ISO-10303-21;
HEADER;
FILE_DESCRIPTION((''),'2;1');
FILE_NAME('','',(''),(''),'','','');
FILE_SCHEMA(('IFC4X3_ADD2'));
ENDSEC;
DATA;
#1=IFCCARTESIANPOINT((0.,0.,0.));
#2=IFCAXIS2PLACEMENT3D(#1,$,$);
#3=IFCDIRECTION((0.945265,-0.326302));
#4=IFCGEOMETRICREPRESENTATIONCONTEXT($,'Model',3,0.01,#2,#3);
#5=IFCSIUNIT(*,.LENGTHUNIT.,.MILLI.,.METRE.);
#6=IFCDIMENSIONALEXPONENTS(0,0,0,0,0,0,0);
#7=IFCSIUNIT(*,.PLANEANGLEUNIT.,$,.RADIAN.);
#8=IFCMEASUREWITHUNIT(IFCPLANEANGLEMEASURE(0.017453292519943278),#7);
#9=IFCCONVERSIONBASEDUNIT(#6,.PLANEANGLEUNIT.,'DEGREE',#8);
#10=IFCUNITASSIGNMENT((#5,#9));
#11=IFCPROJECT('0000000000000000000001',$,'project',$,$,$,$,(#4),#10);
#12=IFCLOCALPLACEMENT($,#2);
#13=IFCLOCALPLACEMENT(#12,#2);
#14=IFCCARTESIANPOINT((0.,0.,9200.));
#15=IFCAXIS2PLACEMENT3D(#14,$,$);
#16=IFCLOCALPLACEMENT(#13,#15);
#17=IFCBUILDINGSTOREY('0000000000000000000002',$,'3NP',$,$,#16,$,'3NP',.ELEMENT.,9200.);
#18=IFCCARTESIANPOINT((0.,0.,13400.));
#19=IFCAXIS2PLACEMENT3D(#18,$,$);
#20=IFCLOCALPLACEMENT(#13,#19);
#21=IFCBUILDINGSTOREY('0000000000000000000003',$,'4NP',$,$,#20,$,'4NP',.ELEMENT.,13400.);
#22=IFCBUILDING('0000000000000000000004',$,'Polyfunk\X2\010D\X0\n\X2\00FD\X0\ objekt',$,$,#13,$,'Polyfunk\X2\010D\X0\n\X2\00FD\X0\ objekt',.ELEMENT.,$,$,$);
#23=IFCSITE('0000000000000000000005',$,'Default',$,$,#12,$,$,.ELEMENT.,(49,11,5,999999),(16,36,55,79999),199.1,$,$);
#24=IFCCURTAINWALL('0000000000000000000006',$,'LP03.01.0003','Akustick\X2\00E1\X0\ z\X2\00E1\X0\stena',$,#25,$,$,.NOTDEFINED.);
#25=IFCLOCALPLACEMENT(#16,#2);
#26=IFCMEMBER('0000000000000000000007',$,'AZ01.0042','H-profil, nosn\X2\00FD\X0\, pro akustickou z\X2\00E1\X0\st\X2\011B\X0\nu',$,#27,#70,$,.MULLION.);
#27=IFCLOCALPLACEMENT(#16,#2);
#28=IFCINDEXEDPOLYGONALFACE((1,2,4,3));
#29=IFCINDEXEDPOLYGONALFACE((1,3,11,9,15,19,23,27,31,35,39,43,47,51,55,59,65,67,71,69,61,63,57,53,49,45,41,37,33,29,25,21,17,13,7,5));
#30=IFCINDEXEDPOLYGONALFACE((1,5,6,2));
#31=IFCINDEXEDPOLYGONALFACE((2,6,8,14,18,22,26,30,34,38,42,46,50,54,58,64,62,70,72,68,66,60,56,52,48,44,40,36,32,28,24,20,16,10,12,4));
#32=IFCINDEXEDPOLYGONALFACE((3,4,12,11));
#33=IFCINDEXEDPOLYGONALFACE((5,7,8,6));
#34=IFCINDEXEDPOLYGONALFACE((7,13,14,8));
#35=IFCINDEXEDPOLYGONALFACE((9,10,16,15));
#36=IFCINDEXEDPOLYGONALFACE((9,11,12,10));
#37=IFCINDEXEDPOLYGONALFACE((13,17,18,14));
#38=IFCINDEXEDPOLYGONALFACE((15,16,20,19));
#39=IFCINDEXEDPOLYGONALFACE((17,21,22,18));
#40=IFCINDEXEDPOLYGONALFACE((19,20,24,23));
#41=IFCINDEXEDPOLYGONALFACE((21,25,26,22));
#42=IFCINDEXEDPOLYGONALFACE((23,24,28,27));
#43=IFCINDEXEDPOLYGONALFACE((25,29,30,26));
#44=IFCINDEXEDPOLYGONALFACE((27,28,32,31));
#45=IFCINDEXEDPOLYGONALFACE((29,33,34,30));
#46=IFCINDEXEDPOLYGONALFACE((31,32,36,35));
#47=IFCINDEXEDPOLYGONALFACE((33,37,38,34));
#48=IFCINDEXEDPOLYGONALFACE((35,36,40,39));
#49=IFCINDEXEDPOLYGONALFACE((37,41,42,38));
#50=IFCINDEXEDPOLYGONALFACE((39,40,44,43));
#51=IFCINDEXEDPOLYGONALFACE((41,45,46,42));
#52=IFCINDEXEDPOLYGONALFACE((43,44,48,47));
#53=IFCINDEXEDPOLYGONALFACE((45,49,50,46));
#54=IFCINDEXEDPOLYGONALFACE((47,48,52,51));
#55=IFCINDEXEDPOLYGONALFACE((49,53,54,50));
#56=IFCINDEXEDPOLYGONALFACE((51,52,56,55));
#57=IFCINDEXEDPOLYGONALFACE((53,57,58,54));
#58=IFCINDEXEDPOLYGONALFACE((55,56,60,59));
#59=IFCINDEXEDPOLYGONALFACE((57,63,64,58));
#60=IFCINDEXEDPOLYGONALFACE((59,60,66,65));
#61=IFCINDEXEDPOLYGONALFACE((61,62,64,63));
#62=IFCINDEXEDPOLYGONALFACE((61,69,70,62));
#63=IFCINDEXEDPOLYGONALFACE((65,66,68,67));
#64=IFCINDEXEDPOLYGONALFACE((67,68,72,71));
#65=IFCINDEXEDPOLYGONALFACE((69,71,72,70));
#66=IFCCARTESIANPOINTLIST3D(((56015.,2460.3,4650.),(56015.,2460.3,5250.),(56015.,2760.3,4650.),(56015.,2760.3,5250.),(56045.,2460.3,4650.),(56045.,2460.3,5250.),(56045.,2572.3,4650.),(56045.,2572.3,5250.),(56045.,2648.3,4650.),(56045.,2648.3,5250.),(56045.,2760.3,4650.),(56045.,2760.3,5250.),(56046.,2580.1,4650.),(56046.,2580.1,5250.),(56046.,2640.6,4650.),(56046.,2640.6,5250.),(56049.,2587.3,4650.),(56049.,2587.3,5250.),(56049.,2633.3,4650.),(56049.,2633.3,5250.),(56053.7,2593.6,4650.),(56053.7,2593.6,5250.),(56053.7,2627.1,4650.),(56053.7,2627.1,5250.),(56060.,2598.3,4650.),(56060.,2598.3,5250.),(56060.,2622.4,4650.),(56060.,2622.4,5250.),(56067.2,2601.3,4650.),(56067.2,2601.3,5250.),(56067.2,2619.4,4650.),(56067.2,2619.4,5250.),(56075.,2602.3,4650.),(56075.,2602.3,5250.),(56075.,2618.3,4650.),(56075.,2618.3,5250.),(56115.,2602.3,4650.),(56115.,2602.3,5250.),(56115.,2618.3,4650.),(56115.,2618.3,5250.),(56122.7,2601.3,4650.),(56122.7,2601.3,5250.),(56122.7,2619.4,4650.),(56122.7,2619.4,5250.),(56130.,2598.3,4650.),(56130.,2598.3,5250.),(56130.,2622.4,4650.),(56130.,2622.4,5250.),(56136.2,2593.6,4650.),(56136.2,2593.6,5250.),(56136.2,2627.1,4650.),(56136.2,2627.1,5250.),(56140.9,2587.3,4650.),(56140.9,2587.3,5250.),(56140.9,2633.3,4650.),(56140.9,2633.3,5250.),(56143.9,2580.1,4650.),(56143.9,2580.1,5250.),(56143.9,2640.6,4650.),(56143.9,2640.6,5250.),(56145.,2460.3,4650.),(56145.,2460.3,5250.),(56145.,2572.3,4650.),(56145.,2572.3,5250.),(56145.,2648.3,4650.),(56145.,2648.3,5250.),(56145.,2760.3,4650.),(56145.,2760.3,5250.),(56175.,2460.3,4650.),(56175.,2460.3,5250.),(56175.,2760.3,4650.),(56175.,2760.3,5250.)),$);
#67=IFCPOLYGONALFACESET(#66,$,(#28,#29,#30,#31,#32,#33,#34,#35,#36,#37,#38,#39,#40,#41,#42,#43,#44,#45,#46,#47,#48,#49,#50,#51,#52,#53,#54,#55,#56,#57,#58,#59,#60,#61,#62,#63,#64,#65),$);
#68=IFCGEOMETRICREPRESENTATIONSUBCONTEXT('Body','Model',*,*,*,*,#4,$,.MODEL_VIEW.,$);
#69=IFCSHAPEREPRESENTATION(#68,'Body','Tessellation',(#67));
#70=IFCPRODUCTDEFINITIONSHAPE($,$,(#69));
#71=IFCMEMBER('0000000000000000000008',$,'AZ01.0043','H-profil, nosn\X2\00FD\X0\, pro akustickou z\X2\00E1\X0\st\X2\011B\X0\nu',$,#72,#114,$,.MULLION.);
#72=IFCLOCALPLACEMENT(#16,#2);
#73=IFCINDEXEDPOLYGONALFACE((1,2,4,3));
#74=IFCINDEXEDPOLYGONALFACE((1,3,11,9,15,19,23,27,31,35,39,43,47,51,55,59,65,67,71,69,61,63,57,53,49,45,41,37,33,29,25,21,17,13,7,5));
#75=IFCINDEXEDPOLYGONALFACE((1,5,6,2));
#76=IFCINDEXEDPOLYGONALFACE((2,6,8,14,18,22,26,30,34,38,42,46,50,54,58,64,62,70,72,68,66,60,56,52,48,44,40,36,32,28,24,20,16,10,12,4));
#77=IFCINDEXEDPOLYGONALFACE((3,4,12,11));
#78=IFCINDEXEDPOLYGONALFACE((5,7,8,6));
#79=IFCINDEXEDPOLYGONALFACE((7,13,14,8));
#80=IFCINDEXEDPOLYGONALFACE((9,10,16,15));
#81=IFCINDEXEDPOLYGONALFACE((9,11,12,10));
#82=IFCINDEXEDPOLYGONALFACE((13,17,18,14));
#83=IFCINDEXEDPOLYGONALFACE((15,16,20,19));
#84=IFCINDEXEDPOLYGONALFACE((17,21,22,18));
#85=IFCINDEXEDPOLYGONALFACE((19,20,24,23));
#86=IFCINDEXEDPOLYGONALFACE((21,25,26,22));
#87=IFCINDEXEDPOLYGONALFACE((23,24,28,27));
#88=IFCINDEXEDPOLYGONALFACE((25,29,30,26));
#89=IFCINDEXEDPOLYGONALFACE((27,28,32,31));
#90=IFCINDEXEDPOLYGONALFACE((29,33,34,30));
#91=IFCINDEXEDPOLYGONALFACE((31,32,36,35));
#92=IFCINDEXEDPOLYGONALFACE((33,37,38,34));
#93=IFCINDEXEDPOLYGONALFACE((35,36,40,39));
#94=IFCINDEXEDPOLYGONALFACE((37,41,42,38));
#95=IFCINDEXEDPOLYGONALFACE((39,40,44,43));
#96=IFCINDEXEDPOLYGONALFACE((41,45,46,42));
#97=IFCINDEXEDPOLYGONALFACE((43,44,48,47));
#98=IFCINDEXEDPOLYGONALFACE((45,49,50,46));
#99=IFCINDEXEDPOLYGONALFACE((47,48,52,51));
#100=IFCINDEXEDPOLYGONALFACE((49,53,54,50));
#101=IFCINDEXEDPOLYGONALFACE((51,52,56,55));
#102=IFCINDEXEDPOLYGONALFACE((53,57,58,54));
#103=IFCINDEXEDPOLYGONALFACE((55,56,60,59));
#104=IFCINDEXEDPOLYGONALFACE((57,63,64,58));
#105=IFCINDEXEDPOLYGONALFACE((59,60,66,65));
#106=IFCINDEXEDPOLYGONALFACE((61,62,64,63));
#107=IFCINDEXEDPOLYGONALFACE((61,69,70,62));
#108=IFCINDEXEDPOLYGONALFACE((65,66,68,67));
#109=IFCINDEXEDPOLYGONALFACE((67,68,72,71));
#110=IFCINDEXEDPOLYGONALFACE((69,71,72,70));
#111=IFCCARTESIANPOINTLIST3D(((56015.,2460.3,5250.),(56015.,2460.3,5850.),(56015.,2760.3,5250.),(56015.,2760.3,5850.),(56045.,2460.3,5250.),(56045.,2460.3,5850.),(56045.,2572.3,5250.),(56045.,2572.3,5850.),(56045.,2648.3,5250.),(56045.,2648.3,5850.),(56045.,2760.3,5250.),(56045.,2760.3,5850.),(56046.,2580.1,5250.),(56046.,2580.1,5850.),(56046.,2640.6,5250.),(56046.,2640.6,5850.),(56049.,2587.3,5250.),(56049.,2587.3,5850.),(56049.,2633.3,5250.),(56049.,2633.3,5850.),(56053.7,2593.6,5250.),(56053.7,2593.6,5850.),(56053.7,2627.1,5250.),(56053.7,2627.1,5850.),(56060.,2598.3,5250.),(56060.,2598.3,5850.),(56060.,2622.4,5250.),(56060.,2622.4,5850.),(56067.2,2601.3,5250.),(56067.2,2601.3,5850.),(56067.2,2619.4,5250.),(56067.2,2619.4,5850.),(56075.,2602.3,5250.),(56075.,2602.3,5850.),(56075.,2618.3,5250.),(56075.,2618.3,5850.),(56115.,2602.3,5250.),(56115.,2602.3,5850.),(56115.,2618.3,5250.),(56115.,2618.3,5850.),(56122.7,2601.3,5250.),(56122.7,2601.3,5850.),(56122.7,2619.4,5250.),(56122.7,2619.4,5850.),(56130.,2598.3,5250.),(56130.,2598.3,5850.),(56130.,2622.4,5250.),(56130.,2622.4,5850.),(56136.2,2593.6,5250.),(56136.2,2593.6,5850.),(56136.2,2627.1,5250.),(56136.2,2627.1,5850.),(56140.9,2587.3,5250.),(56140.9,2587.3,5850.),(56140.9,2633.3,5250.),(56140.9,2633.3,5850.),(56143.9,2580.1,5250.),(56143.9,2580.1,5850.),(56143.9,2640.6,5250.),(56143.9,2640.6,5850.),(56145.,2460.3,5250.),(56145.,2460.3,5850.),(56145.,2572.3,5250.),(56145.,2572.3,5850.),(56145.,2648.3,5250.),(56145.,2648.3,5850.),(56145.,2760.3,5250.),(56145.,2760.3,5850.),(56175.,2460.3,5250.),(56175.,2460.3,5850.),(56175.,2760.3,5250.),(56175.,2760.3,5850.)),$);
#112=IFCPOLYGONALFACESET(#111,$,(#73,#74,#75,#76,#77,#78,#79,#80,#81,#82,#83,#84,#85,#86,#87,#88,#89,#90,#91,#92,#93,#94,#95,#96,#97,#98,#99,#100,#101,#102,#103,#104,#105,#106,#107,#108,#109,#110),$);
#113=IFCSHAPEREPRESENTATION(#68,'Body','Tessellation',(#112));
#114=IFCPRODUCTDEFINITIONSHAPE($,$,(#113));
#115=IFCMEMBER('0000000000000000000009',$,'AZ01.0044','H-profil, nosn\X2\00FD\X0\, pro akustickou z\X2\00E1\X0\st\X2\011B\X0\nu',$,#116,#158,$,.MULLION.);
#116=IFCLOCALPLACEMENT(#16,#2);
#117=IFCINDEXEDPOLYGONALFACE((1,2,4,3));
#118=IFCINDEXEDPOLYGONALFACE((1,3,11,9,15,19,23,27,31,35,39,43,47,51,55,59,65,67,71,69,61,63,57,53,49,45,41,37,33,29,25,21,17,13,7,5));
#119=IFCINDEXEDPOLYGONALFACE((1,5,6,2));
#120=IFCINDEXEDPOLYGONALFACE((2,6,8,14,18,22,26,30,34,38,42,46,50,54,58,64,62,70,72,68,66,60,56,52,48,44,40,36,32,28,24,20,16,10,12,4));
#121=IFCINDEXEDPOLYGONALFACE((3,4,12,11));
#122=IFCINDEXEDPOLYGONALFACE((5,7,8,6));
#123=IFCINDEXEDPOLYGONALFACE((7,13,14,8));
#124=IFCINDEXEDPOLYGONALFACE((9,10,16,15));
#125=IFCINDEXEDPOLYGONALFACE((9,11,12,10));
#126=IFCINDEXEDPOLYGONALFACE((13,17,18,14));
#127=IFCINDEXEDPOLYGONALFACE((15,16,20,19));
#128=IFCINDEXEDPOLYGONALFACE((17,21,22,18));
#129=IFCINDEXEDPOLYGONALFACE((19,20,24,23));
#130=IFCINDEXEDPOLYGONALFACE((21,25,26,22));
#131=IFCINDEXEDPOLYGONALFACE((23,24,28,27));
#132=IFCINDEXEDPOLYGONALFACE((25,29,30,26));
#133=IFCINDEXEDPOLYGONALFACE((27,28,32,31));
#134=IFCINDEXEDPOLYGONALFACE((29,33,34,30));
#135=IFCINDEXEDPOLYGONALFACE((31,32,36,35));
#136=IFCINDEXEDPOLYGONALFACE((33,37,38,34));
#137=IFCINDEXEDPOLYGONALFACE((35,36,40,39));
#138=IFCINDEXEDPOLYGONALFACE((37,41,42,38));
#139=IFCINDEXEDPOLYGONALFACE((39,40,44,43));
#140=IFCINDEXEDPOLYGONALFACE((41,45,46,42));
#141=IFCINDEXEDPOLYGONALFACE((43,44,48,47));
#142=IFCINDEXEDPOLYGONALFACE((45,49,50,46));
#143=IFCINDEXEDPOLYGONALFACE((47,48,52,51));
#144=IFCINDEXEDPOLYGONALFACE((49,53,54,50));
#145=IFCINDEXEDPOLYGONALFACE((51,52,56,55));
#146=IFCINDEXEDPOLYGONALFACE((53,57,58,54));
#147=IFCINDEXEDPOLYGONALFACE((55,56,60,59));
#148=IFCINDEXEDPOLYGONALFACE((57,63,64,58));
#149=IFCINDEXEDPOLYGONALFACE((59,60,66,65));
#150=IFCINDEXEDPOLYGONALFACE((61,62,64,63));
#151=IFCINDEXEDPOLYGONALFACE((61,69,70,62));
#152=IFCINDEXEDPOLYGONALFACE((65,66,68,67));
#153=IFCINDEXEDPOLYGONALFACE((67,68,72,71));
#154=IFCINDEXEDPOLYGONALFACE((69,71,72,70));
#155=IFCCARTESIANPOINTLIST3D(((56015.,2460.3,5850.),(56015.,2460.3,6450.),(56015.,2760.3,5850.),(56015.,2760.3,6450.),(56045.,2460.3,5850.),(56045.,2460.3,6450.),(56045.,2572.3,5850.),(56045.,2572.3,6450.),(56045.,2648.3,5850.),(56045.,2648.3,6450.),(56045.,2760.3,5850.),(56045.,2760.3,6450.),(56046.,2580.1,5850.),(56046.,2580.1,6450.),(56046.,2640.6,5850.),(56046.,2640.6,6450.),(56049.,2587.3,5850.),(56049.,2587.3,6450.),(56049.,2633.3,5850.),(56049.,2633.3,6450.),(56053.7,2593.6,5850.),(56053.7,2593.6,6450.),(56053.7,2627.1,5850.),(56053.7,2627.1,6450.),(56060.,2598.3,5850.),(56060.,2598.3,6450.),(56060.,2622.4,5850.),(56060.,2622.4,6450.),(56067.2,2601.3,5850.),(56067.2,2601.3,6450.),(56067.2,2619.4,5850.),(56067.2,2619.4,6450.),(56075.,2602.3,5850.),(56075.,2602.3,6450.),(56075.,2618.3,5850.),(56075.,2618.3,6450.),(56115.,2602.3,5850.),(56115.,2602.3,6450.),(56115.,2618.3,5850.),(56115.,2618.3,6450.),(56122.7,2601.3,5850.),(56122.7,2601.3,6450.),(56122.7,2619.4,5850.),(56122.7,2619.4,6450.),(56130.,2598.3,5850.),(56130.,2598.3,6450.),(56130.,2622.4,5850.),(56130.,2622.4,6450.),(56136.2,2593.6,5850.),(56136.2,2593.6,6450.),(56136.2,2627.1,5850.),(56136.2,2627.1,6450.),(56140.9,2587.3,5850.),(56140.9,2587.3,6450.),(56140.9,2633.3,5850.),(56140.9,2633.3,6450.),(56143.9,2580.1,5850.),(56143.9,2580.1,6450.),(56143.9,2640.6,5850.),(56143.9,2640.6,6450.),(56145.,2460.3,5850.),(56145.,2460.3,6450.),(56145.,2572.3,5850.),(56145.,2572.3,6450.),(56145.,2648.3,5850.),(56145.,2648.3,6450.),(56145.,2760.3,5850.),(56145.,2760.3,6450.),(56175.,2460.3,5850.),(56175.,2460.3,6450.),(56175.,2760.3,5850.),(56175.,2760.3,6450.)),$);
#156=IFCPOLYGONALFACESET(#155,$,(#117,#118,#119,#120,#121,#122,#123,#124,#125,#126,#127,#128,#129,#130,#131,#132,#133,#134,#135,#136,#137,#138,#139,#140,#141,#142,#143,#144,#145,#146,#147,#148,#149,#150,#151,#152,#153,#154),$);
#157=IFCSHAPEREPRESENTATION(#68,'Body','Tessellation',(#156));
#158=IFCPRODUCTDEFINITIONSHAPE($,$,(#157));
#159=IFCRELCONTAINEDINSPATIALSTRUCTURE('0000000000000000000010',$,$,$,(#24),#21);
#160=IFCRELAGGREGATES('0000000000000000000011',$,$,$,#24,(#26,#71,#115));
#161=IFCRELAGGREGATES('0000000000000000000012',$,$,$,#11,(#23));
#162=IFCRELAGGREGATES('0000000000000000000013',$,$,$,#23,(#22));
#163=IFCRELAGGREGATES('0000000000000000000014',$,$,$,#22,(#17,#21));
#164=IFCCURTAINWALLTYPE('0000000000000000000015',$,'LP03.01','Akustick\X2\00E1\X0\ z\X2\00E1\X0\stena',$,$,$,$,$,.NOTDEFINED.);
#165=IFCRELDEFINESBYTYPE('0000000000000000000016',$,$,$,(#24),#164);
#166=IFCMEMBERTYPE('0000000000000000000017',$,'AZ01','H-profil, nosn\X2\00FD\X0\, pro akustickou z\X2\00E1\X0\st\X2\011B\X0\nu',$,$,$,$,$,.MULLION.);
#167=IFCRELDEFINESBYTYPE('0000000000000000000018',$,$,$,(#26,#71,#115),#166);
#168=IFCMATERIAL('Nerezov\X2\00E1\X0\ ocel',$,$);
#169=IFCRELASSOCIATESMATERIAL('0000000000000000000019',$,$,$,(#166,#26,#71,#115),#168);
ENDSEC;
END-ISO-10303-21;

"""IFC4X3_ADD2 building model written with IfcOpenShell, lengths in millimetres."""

from ifc_helpers import new_model, entity, si_unit, converted_unit, direction, frame, frame_2d, origin, place, context, subcontext, project, spatial, polyline, circle_curve, parameter, trimmed, segment, composite_curve, outline, extrude, source, transform, mapped, material, material_profile, profile_set, profile_usage, type_object, element, aggregate, save


model = new_model("IFC4X3_ADD2")

# Units and contexts
model_context = context("Model", 3, precision=0.01, world=origin(), true_north=direction((0.945265, -0.326302)))
body_context = subcontext(model_context, "Body", "Model", "MODEL_VIEW")
ifc_project = project(units=[si_unit("LENGTHUNIT", "METRE", prefix="MILLI"), converted_unit("PLANEANGLEUNIT", "DEGREE", entity("IfcPlaneAngleMeasure", 0.017453292519943278), si_unit("PLANEANGLEUNIT", "RADIAN"), dimensions=[0, 0, 0, 0, 0, 0, 0])], contexts=[model_context])

# Site, building, storey
site_placement = place(None, origin())
site = spatial("IfcSite", under=ifc_project, at=site_placement, Name="Default", CompositionType="ELEMENT", RefLatitude=(49, 11, 5, 999999), RefLongitude=(16, 36, 55, 79999), RefElevation=199.1)
building_placement = place(site_placement, origin())
building = spatial("IfcBuilding", under=site, at=building_placement, Name="Polyfunkčný objekt", LongName="Polyfunkčný objekt", CompositionType="ELEMENT")
storey_1_placement = place(building_placement, frame((0.0, 0.0, 9200.0)))
storey_1 = spatial("IfcBuildingStorey", under=building, at=storey_1_placement, Name="3NP", LongName="3NP", CompositionType="ELEMENT", Elevation=9200.0)

# Shared definitions
storey_2_placement = place(building_placement, frame((0.0, 0.0, 13400.0)))
storey_2 = spatial("IfcBuildingStorey", under=building, at=storey_2_placement, Name="4NP", LongName="4NP", CompositionType="ELEMENT", Elevation=13400.0)

# Shared definitions
curtain_wall_type_1 = type_object("IfcCurtainWallType", Name="LP03.01", Description="Akustická zástena", PredefinedType="NOTDEFINED")
ifc_material_1 = material(Name="Nerezová ocel")
ifc_material_profile_1 = material_profile(ifc_material_1, outline(composite_curve([segment(polyline([(50.0, -150.0), (80.0, -150.0)]), True, "CONTINUOUS"), segment(polyline([(80.0, -150.0), (80.0, 150.0)]), True, "CONTINUOUS"), segment(polyline([(80.0, 150.0), (50.0, 150.0)]), True, "CONTINUOUS"), segment(polyline([(50.0, 150.0), (50.0, 38.0)]), True, "CONTINUOUS"), segment(trimmed(circle_curve(frame_2d((20.0, 38.0), x_axis=(0.0, 1.0)), 30.0), [parameter(180.0)], [parameter(270.0)], True, "PARAMETER"), False, "CONTINUOUS"), segment(polyline([(20.0, 8.0), (-20.0, 8.0)]), True, "CONTINUOUS"), segment(trimmed(circle_curve(frame_2d((-20.0, 38.0), x_axis=(0.0, 1.0)), 30.0), [parameter(90.0)], [parameter(180.0)], True, "PARAMETER"), False, "CONTINUOUS"), segment(polyline([(-50.0, 38.0), (-50.0, 150.0)]), True, "CONTINUOUS"), segment(polyline([(-50.0, 150.0), (-80.0, 150.0)]), True, "CONTINUOUS"), segment(polyline([(-80.0, 150.0), (-80.0, -150.0)]), True, "CONTINUOUS"), segment(polyline([(-80.0, -150.0), (-50.0, -150.0)]), True, "CONTINUOUS"), segment(polyline([(-50.0, -150.0), (-50.0, -38.0)]), True, "CONTINUOUS"), segment(trimmed(circle_curve(frame_2d((-20.0, -38.0), x_axis=(0.0, 1.0)), 30.0), [parameter(0.0)], [parameter(90.0)], True, "PARAMETER"), False, "CONTINUOUS"), segment(polyline([(-20.0, -8.0), (20.0, -8.0)]), True, "CONTINUOUS"), segment(trimmed(circle_curve(frame_2d((20.0, -38.0), x_axis=(0.0, 1.0)), 30.0), [parameter(270.0)], [parameter(0.0)], True, "PARAMETER"), False, "CONTINUOUS"), segment(polyline([(50.0, -38.0), (50.0, -150.0)]), True, "CONTINUOUS")], self_intersect=False)), Name="Profil zástena")
ifc_profile_set_1 = profile_set([ifc_material_profile_1], Name="Profil zástena")
ifc_profile_usage_1 = profile_usage(ifc_profile_set_1)
member_type_1 = type_object("IfcMemberType", Name="AZ01", Description="H-profil, nosný, pro akustickou zástěnu", PredefinedType="MULLION", material=ifc_profile_set_1)

# Curtain wall, members
curtain_wall_1_placement = place(storey_2_placement, frame((0.0, 0.0, -13400.0)))
curtain_wall_1 = element("IfcCurtainWall", 1, at=curtain_wall_1_placement, inside=storey_2, type_object=curtain_wall_type_1, Name="LP03.01.0003", Description="Akustická zástena", PredefinedType="NOTDEFINED")
shared_shape_1 = source(origin(), body_context, "Body", "SweptSolid", [
    extrude(outline(composite_curve([segment(polyline([(-150.0, -50.0), (-150.0, -80.0)]), True, "CONTINUOUS"), segment(polyline([(-150.0, -80.0), (150.0, -80.0)]), True, "CONTINUOUS"), segment(polyline([(150.0, -80.0), (150.0, -50.0)]), True, "CONTINUOUS"), segment(polyline([(150.0, -50.0), (38.0, -50.0)]), True, "CONTINUOUS"), segment(trimmed(circle_curve(frame_2d((38.0, -20.0), x_axis=(1.0, 0.0)), 30.0), [parameter(180.0)], [parameter(270.0)], True, "PARAMETER"), False, "CONTINUOUS"), segment(polyline([(8.0, -20.0), (8.0, 20.0)]), True, "CONTINUOUS"), segment(trimmed(circle_curve(frame_2d((38.0, 20.0), x_axis=(1.0, 0.0)), 30.0), [parameter(90.0)], [parameter(180.0)], True, "PARAMETER"), False, "CONTINUOUS"), segment(polyline([(38.0, 50.0), (150.0, 50.0)]), True, "CONTINUOUS"), segment(polyline([(150.0, 50.0), (150.0, 80.0)]), True, "CONTINUOUS"), segment(polyline([(150.0, 80.0), (-150.0, 80.0)]), True, "CONTINUOUS"), segment(polyline([(-150.0, 80.0), (-150.0, 50.0)]), True, "CONTINUOUS"), segment(polyline([(-150.0, 50.0), (-38.0, 50.0)]), True, "CONTINUOUS"), segment(trimmed(circle_curve(frame_2d((-38.0, 20.0), x_axis=(1.0, 0.0)), 30.0), [parameter(0.0)], [parameter(90.0)], True, "PARAMETER"), False, "CONTINUOUS"), segment(polyline([(-8.0, 20.0), (-8.0, -20.0)]), True, "CONTINUOUS"), segment(trimmed(circle_curve(frame_2d((-38.0, -20.0), x_axis=(1.0, 0.0)), 30.0), [parameter(270.0)], [parameter(0.0)], True, "PARAMETER"), False, "CONTINUOUS"), segment(polyline([(-38.0, -50.0), (-150.0, -50.0)]), True, "CONTINUOUS")], self_intersect=False)), frame((0.0, 0.0, -600.0), z_axis=(0.0, 0.0, -1.0), x_axis=(1.0, 0.0, 0.0)), (0.0, 0.0, -1.0), 600.0),
])
member_1_placement = place(curtain_wall_1_placement, frame((56095.0, 2610.3, 13850.0), z_axis=(0.0, 0.0, -1.0), x_axis=(0.0, 1.0, 0.0)))
member_1 = element("IfcMember", 2, at=member_1_placement, type_object=member_type_1, material=ifc_profile_usage_1, Name="AZ01.0042", Description="H-profil, nosný, pro akustickou zástěnu", PredefinedType="MULLION", context=body_context, shape_type="MappedRepresentation", body=[
    mapped(shared_shape_1, transform((0.0, 0.0, 0.0), scale=1.0)),
])
member_2_placement = place(curtain_wall_1_placement, frame((56095.0, 2610.3, 14450.0), z_axis=(0.0, 0.0, -1.0), x_axis=(0.0, 1.0, 0.0)))
member_2 = element("IfcMember", 3, at=member_2_placement, type_object=member_type_1, material=ifc_profile_usage_1, Name="AZ01.0043", Description="H-profil, nosný, pro akustickou zástěnu", PredefinedType="MULLION", context=body_context, shape_type="MappedRepresentation", body=[
    mapped(shared_shape_1, transform((0.0, 0.0, 0.0), scale=1.0)),
])
member_3_placement = place(curtain_wall_1_placement, frame((56095.0, 2610.3, 15050.0), z_axis=(0.0, 0.0, -1.0), x_axis=(0.0, 1.0, 0.0)))
member_3 = element("IfcMember", 4, at=member_3_placement, type_object=member_type_1, material=ifc_profile_usage_1, Name="AZ01.0044", Description="H-profil, nosný, pro akustickou zástěnu", PredefinedType="MULLION", context=body_context, shape_type="MappedRepresentation", body=[
    mapped(shared_shape_1, transform((0.0, 0.0, 0.0), scale=1.0)),
])
aggregate(curtain_wall_1, [member_1, member_2, member_3])

save(model, "model.ifc")
